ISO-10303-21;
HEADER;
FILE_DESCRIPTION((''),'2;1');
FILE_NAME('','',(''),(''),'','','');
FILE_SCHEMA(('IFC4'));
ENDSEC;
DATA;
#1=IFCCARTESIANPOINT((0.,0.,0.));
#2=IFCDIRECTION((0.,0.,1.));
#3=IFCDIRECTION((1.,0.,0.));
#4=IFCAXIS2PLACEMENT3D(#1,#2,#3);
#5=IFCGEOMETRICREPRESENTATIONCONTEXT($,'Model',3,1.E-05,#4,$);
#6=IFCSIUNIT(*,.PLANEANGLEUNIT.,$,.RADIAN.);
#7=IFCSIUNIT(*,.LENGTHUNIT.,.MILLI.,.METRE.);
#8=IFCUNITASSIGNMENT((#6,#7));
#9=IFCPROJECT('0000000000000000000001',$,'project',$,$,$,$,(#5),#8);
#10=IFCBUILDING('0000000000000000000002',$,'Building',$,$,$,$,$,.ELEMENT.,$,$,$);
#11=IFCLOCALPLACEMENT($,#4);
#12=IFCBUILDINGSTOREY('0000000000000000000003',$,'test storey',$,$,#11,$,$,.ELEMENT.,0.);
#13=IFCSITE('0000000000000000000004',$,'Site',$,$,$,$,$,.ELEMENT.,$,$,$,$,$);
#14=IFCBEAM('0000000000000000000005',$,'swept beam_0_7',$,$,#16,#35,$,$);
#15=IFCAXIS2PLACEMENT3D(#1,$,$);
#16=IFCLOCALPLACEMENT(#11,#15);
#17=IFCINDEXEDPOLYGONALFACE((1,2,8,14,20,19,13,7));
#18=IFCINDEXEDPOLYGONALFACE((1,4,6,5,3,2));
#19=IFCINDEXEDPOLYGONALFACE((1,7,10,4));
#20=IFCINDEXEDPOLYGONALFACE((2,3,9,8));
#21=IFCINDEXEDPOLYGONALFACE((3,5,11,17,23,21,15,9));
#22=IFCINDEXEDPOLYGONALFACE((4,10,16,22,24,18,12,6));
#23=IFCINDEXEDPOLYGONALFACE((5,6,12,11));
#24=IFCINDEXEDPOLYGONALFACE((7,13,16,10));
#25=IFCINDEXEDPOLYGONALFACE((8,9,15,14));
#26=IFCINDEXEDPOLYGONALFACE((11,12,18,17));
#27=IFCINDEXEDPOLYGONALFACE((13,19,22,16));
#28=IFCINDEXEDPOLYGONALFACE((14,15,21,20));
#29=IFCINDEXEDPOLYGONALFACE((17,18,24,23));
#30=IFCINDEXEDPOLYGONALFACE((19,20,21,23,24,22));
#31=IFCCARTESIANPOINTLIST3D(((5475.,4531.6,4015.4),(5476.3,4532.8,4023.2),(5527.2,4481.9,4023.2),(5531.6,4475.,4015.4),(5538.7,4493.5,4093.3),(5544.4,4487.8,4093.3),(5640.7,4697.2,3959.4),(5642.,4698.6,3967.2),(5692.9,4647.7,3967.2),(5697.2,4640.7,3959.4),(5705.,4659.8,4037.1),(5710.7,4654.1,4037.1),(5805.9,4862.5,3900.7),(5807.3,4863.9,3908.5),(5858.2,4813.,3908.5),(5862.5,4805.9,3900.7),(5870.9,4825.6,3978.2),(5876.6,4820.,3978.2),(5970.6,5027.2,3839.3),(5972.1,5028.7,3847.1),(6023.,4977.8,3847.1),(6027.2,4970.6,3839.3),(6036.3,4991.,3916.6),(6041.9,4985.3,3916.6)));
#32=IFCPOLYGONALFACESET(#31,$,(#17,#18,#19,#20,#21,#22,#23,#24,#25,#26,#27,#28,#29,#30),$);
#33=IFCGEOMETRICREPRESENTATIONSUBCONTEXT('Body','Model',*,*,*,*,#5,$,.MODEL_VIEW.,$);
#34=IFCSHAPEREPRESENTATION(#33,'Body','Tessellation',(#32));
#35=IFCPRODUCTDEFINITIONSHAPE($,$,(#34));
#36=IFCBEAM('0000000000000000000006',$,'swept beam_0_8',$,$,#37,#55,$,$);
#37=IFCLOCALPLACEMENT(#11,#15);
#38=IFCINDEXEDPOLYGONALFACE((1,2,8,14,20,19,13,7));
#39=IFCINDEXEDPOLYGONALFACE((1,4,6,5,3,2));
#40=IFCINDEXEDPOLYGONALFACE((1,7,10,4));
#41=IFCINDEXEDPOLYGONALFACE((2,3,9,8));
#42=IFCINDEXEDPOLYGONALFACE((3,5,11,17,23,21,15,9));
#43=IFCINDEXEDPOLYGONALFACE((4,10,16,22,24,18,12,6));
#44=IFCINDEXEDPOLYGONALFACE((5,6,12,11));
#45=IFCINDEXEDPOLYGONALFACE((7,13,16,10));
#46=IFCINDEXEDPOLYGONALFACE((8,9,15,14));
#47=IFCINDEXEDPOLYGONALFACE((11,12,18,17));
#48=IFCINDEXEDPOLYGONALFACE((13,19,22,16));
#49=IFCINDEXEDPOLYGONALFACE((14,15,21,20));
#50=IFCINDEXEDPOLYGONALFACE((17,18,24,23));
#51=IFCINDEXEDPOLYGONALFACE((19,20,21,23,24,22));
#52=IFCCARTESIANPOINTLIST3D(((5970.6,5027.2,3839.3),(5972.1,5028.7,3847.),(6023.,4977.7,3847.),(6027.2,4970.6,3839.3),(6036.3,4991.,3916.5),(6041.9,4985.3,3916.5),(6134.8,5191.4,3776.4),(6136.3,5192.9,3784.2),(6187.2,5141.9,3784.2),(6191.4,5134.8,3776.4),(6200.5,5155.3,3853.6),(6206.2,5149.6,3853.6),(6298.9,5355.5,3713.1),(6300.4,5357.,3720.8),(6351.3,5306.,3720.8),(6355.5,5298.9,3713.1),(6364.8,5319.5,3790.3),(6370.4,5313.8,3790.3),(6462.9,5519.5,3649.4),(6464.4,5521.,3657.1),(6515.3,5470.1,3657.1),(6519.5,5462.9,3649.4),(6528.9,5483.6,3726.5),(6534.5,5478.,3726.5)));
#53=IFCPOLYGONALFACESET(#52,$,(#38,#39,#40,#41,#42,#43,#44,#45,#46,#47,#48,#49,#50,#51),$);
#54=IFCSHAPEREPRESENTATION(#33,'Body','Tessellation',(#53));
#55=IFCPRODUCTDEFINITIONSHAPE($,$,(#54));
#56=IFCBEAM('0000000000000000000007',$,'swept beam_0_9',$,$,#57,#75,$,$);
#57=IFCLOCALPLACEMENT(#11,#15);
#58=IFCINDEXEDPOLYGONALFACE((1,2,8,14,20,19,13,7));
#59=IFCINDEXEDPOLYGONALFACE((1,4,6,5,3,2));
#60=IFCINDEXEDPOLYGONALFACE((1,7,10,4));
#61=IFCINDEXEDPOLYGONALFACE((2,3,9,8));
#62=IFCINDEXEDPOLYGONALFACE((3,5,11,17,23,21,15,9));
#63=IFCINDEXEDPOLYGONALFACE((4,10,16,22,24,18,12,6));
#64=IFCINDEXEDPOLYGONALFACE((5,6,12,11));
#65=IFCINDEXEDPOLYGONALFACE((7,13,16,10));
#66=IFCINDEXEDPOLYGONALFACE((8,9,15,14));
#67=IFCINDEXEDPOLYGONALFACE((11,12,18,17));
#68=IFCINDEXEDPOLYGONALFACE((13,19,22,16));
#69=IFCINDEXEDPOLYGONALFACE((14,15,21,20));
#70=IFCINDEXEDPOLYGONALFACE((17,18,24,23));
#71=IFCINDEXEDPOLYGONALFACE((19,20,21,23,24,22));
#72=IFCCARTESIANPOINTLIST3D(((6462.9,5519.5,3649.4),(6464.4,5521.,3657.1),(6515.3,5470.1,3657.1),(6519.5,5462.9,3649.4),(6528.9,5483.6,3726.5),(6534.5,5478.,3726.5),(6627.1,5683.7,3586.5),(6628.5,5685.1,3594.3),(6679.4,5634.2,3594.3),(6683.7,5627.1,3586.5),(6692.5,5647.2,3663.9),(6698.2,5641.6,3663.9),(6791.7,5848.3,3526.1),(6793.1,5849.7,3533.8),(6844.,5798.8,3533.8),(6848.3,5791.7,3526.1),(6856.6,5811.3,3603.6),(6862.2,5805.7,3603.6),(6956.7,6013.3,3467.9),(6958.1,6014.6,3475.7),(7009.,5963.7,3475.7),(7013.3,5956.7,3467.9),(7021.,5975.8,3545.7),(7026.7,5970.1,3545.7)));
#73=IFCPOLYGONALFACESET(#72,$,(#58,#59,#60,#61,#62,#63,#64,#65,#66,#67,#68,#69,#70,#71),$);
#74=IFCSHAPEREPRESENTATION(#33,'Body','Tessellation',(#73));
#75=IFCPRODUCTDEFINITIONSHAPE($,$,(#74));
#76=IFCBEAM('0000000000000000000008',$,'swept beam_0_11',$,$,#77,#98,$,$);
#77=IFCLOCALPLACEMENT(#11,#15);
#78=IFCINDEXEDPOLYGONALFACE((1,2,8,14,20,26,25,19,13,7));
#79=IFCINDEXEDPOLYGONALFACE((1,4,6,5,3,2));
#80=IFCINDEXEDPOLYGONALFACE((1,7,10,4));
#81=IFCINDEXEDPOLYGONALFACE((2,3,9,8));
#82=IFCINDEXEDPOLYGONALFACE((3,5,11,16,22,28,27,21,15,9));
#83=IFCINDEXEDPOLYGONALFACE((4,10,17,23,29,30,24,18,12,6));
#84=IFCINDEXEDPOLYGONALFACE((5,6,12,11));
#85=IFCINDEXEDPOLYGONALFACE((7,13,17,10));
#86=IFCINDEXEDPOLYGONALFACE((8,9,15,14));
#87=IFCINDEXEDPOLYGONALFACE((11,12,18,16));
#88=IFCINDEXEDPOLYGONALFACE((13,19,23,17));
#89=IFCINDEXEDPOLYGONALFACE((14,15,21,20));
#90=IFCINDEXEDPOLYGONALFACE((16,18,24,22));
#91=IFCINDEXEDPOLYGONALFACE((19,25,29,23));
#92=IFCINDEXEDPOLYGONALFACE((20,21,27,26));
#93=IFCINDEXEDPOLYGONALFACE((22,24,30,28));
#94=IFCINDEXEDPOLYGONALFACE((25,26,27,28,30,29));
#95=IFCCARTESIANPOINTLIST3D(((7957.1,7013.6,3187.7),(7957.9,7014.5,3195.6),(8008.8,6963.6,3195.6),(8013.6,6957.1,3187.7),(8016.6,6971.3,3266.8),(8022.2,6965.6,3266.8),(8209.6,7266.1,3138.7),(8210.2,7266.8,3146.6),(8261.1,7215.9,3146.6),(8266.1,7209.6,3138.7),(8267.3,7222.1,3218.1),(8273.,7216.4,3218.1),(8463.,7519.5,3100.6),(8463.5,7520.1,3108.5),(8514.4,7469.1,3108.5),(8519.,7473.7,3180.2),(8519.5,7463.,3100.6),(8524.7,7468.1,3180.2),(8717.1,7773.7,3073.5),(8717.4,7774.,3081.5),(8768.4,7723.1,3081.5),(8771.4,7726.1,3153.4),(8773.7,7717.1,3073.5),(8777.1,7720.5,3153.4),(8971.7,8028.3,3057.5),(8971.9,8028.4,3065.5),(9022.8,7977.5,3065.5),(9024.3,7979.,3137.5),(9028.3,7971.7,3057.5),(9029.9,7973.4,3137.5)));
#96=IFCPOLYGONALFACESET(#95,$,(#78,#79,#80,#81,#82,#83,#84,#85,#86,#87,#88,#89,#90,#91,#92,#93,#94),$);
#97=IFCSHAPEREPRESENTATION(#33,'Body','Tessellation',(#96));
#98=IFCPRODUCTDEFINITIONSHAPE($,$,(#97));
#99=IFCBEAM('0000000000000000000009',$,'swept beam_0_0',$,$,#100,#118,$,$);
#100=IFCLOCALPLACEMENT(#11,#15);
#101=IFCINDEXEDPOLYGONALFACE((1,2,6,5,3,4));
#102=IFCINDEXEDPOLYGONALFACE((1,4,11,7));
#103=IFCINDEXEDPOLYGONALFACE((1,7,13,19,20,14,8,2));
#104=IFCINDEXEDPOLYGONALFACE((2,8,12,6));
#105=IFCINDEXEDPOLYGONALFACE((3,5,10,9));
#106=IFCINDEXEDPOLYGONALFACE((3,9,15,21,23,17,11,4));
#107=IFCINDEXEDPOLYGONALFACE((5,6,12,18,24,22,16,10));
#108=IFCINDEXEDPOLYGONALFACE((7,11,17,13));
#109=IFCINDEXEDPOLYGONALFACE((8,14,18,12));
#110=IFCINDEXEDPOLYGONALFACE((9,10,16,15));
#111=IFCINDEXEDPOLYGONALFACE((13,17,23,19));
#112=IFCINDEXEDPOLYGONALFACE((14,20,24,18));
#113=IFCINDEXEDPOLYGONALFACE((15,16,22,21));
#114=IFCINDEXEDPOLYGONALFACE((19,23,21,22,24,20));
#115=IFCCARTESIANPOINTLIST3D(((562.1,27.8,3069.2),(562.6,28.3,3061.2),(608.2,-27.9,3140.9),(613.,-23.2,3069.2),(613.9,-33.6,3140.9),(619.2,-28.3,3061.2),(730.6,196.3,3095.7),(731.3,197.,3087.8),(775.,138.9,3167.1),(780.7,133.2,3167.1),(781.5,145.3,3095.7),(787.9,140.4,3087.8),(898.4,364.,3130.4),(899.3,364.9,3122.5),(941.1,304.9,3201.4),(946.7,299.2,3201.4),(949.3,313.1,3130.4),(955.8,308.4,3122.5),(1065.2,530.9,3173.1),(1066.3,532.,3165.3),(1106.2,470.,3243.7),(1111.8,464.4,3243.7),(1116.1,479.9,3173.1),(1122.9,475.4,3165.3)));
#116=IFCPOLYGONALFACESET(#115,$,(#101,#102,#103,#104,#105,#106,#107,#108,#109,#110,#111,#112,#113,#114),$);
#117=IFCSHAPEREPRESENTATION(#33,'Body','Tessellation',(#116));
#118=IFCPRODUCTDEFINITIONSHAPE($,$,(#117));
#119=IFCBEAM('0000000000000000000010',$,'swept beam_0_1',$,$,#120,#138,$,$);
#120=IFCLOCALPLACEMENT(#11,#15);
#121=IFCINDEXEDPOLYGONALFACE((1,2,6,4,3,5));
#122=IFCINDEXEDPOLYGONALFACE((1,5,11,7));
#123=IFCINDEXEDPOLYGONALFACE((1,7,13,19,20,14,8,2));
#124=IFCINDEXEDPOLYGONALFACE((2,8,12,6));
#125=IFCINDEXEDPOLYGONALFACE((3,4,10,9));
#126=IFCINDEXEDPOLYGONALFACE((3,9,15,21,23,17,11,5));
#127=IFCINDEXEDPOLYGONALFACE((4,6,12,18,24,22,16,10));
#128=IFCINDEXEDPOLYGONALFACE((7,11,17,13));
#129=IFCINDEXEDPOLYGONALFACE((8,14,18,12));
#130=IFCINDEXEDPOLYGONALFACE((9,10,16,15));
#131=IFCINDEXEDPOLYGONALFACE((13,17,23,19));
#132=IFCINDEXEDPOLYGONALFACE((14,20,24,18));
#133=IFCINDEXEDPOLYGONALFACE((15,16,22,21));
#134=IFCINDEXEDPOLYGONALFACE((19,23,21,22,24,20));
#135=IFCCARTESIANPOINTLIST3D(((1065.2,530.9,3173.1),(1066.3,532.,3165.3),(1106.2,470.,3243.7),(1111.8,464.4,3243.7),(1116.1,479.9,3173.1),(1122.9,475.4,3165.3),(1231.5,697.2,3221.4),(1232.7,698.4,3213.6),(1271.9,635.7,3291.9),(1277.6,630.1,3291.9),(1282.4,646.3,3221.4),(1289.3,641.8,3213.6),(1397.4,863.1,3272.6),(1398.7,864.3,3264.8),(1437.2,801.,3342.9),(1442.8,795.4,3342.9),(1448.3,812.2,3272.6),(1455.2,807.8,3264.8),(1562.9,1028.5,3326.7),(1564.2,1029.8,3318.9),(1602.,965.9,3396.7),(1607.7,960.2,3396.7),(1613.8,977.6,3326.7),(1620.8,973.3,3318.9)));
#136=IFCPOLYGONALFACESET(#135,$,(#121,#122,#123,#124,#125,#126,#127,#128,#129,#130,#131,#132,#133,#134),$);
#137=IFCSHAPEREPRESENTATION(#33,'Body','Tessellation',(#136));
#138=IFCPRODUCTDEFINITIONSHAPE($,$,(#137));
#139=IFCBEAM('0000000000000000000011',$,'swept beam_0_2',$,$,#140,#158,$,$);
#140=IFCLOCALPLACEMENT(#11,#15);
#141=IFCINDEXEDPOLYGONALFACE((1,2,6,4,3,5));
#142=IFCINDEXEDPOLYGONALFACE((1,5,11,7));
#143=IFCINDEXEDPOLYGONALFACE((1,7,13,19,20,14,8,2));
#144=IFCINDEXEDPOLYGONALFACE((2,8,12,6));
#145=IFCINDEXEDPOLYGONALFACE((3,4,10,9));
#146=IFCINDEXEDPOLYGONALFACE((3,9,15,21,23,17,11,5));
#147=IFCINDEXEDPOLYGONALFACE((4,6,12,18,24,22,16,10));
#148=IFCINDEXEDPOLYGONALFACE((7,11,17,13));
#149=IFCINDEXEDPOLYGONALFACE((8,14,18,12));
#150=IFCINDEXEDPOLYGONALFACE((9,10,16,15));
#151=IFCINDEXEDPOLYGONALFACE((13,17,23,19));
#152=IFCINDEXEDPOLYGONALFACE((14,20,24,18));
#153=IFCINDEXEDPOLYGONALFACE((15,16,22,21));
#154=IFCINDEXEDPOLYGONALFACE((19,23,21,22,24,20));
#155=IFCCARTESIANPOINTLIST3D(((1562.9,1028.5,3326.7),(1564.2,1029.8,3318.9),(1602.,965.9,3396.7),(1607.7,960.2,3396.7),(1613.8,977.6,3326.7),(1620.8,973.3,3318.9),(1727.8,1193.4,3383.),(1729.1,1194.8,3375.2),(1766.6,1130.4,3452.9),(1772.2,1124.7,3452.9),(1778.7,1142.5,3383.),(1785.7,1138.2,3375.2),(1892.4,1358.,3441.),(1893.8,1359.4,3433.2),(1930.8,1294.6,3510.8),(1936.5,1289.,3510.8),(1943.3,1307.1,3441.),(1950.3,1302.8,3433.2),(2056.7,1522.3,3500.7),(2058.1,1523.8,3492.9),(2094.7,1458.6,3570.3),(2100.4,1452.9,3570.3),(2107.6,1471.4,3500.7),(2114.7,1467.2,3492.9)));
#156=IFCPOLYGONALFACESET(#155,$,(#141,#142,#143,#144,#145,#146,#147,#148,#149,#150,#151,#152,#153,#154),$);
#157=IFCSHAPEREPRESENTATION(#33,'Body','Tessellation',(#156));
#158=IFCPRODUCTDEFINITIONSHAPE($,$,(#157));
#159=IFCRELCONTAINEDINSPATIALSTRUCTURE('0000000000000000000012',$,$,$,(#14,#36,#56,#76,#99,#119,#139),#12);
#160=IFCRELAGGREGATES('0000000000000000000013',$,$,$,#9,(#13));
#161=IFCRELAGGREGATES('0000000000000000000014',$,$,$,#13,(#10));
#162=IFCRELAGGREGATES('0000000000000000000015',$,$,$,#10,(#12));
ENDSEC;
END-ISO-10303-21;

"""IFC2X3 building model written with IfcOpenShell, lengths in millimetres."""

from ifc_helpers import new_model, entity, si_unit, origin_with_axes, place, context, subcontext, project, spatial, element, save


model = new_model("IFC2X3")

# Units and contexts
model_context = context("Model", 3, precision=1e-05, world=origin_with_axes())
body_context = subcontext(model_context, "Body", "Model", "MODEL_VIEW")
ifc_project = project(units=[si_unit("PLANEANGLEUNIT", "RADIAN"), si_unit("LENGTHUNIT", "METRE", prefix="MILLI")], contexts=[model_context])

# Site, building, storey
site = spatial("IfcSite", under=ifc_project, Name="Site", CompositionType="ELEMENT")
building = spatial("IfcBuilding", under=site, Name="Building", CompositionType="ELEMENT")
storey_placement = place(None, origin_with_axes())
storey = spatial("IfcBuildingStorey", under=building, at=storey_placement, Name="test storey", CompositionType="ELEMENT", Elevation=0.0)

# Beams
beam_1_placement = place(storey_placement, origin_with_axes())
element("IfcBeam", 1, at=beam_1_placement, inside=storey, Name="swept beam_0_7", context=body_context, shape_type="SweptSolid", body=[
    entity("IfcRevolvedAreaSolid", entity("IfcArbitraryClosedProfileDef", "AREA", None, entity("IfcPolyline", [entity("IfcCartesianPoint", [80.0, -40.0]), entity("IfcCartesianPoint", [80.0, -32.0]), entity("IfcCartesianPoint", [8.0, -32.0]), entity("IfcCartesianPoint", [8.0, 40.0]), entity("IfcCartesianPoint", [0.0, 40.0]), entity("IfcCartesianPoint", [0.0, -40.0]), entity("IfcCartesianPoint", [80.0, -40.0])])), entity("IfcAxis2Placement3D", entity("IfcCartesianPoint", [5503.3, 4503.3, 4015.4]), entity("IfcDirection", [-0.6887, -0.6887, 0.2269]), entity("IfcDirection", [0.1605, 0.1605, 0.9739])), entity("IfcAxis1Placement", entity("IfcCartesianPoint", [-20950.4, 0.0, 0.0]), entity("IfcDirection", [0.0, 1.0, 0.0])), 0.034498),
])
beam_2_placement = place(storey_placement, origin_with_axes())
element("IfcBeam", 2, at=beam_2_placement, inside=storey, Name="swept beam_0_8", context=body_context, shape_type="SweptSolid", body=[
    entity("IfcRevolvedAreaSolid", entity("IfcArbitraryClosedProfileDef", "AREA", None, entity("IfcPolyline", [entity("IfcCartesianPoint", [80.0, -40.0]), entity("IfcCartesianPoint", [80.0, -32.0]), entity("IfcCartesianPoint", [8.0, -32.0]), entity("IfcCartesianPoint", [8.0, 40.0]), entity("IfcCartesianPoint", [0.0, 40.0]), entity("IfcCartesianPoint", [0.0, -40.0]), entity("IfcCartesianPoint", [80.0, -40.0])])), entity("IfcAxis2Placement3D", entity("IfcCartesianPoint", [5998.9, 4998.9, 3839.3]), entity("IfcDirection", [-0.6827, -0.6827, 0.2604]), entity("IfcDirection", [0.1841, 0.1841, 0.9655])), entity("IfcAxis1Placement", entity("IfcCartesianPoint", [-123370.1, 0.0, 0.0]), entity("IfcDirection", [0.0, 1.0, 0.0])), 0.005849),
])
beam_3_placement = place(storey_placement, origin_with_axes())
element("IfcBeam", 3, at=beam_3_placement, inside=storey, Name="swept beam_0_9", context=body_context, shape_type="SweptSolid", body=[
    entity("IfcRevolvedAreaSolid", entity("IfcArbitraryClosedProfileDef", "AREA", None, entity("IfcPolyline", [entity("IfcCartesianPoint", [-80.0, 40.0]), entity("IfcCartesianPoint", [-80.0, 32.0]), entity("IfcCartesianPoint", [-8.0, 32.0]), entity("IfcCartesianPoint", [-8.0, -40.0]), entity("IfcCartesianPoint", [0.0, -40.0]), entity("IfcCartesianPoint", [0.0, 40.0]), entity("IfcCartesianPoint", [-80.0, 40.0])])), entity("IfcAxis2Placement3D", entity("IfcCartesianPoint", [6491.2, 5491.2, 3649.4]), entity("IfcDirection", [-0.6816, -0.6816, 0.266]), entity("IfcDirection", [-0.1881, -0.1881, -0.964])), entity("IfcAxis1Placement", entity("IfcCartesianPoint", [-23916.3, 0.0, 0.0]), entity("IfcDirection", [0.0, 1.0, 0.0])), 0.030172),
])
beam_4_placement = place(storey_placement, origin_with_axes())
element("IfcBeam", 4, at=beam_4_placement, inside=storey, Name="swept beam_0_11", context=body_context, shape_type="SweptSolid", body=[
    entity("IfcRevolvedAreaSolid", entity("IfcArbitraryClosedProfileDef", "AREA", None, entity("IfcPolyline", [entity("IfcCartesianPoint", [-80.0, 40.0]), entity("IfcCartesianPoint", [-80.0, 32.0]), entity("IfcCartesianPoint", [-8.0, 32.0]), entity("IfcCartesianPoint", [-8.0, -40.0]), entity("IfcCartesianPoint", [0.0, -40.0]), entity("IfcCartesianPoint", [0.0, 40.0]), entity("IfcCartesianPoint", [-80.0, 40.0])])), entity("IfcAxis2Placement3D", entity("IfcCartesianPoint", [7985.4, 6985.4, 3187.7]), entity("IfcDirection", [-0.699, -0.699, 0.1514]), entity("IfcDirection", [-0.107, -0.107, -0.9885])), entity("IfcAxis1Placement", entity("IfcCartesianPoint", [-11725.9, 0.0, 0.0]), entity("IfcDirection", [0.0, 1.0, 0.0])), 0.122951),
])
beam_5_placement = place(storey_placement, origin_with_axes())
element("IfcBeam", 5, at=beam_5_placement, inside=storey, Name="swept beam_0_0", context=body_context, shape_type="SweptSolid", body=[
    entity("IfcRevolvedAreaSolid", entity("IfcArbitraryClosedProfileDef", "AREA", None, entity("IfcPolyline", [entity("IfcCartesianPoint", [-80.0, 40.0]), entity("IfcCartesianPoint", [-80.0, 32.0]), entity("IfcCartesianPoint", [-8.0, 32.0]), entity("IfcCartesianPoint", [-8.0, -40.0]), entity("IfcCartesianPoint", [0.0, -40.0]), entity("IfcCartesianPoint", [0.0, 40.0]), entity("IfcCartesianPoint", [-80.0, 40.0])])), entity("IfcAxis2Placement3D", entity("IfcCartesianPoint", [590.9, 0.0, 3061.2]), entity("IfcDirection", [-0.704, -0.704, -0.0936]), entity("IfcDirection", [0.0662, 0.0662, -0.9956])), entity("IfcAxis1Placement", entity("IfcCartesianPoint", [-7017.6, 0.0, 0.0]), entity("IfcDirection", [0.0, 1.0, 0.0])), 0.102624),
])
beam_6_placement = place(storey_placement, origin_with_axes())
element("IfcBeam", 6, at=beam_6_placement, inside=storey, Name="swept beam_0_1", context=body_context, shape_type="SweptSolid", body=[
    entity("IfcRevolvedAreaSolid", entity("IfcArbitraryClosedProfileDef", "AREA", None, entity("IfcPolyline", [entity("IfcCartesianPoint", [-80.0, 40.0]), entity("IfcCartesianPoint", [-80.0, 32.0]), entity("IfcCartesianPoint", [-8.0, 32.0]), entity("IfcCartesianPoint", [-8.0, -40.0]), entity("IfcCartesianPoint", [0.0, -40.0]), entity("IfcCartesianPoint", [0.0, 40.0]), entity("IfcCartesianPoint", [-80.0, 40.0])])), entity("IfcAxis2Placement3D", entity("IfcCartesianPoint", [1094.6, 503.7, 3165.3]), entity("IfcDirection", [-0.6935, -0.6935, -0.1951]), entity("IfcDirection", [0.1379, 0.1379, -0.9808])), entity("IfcAxis1Placement", entity("IfcCartesianPoint", [-19519.6, 0.0, 0.0]), entity("IfcDirection", [0.0, 1.0, 0.0])), 0.036923),
])
beam_7_placement = place(storey_placement, origin_with_axes())
element("IfcBeam", 7, at=beam_7_placement, inside=storey, Name="swept beam_0_2", context=body_context, shape_type="SweptSolid", body=[
    entity("IfcRevolvedAreaSolid", entity("IfcArbitraryClosedProfileDef", "AREA", None, entity("IfcPolyline", [entity("IfcCartesianPoint", [-80.0, 40.0]), entity("IfcCartesianPoint", [-80.0, 32.0]), entity("IfcCartesianPoint", [-8.0, 32.0]), entity("IfcCartesianPoint", [-8.0, -40.0]), entity("IfcCartesianPoint", [0.0, -40.0]), entity("IfcCartesianPoint", [0.0, 40.0]), entity("IfcCartesianPoint", [-80.0, 40.0])])), entity("IfcAxis2Placement3D", entity("IfcCartesianPoint", [1592.5, 1001.6, 3318.9]), entity("IfcDirection", [-0.688, -0.688, -0.2312]), entity("IfcDirection", [0.1635, 0.1635, -0.9729])), entity("IfcAxis1Placement", entity("IfcCartesianPoint", [-33077.8, 0.0, 0.0]), entity("IfcDirection", [0.0, 1.0, 0.0])), 0.021762),
])

save(model, "model.ifc")
